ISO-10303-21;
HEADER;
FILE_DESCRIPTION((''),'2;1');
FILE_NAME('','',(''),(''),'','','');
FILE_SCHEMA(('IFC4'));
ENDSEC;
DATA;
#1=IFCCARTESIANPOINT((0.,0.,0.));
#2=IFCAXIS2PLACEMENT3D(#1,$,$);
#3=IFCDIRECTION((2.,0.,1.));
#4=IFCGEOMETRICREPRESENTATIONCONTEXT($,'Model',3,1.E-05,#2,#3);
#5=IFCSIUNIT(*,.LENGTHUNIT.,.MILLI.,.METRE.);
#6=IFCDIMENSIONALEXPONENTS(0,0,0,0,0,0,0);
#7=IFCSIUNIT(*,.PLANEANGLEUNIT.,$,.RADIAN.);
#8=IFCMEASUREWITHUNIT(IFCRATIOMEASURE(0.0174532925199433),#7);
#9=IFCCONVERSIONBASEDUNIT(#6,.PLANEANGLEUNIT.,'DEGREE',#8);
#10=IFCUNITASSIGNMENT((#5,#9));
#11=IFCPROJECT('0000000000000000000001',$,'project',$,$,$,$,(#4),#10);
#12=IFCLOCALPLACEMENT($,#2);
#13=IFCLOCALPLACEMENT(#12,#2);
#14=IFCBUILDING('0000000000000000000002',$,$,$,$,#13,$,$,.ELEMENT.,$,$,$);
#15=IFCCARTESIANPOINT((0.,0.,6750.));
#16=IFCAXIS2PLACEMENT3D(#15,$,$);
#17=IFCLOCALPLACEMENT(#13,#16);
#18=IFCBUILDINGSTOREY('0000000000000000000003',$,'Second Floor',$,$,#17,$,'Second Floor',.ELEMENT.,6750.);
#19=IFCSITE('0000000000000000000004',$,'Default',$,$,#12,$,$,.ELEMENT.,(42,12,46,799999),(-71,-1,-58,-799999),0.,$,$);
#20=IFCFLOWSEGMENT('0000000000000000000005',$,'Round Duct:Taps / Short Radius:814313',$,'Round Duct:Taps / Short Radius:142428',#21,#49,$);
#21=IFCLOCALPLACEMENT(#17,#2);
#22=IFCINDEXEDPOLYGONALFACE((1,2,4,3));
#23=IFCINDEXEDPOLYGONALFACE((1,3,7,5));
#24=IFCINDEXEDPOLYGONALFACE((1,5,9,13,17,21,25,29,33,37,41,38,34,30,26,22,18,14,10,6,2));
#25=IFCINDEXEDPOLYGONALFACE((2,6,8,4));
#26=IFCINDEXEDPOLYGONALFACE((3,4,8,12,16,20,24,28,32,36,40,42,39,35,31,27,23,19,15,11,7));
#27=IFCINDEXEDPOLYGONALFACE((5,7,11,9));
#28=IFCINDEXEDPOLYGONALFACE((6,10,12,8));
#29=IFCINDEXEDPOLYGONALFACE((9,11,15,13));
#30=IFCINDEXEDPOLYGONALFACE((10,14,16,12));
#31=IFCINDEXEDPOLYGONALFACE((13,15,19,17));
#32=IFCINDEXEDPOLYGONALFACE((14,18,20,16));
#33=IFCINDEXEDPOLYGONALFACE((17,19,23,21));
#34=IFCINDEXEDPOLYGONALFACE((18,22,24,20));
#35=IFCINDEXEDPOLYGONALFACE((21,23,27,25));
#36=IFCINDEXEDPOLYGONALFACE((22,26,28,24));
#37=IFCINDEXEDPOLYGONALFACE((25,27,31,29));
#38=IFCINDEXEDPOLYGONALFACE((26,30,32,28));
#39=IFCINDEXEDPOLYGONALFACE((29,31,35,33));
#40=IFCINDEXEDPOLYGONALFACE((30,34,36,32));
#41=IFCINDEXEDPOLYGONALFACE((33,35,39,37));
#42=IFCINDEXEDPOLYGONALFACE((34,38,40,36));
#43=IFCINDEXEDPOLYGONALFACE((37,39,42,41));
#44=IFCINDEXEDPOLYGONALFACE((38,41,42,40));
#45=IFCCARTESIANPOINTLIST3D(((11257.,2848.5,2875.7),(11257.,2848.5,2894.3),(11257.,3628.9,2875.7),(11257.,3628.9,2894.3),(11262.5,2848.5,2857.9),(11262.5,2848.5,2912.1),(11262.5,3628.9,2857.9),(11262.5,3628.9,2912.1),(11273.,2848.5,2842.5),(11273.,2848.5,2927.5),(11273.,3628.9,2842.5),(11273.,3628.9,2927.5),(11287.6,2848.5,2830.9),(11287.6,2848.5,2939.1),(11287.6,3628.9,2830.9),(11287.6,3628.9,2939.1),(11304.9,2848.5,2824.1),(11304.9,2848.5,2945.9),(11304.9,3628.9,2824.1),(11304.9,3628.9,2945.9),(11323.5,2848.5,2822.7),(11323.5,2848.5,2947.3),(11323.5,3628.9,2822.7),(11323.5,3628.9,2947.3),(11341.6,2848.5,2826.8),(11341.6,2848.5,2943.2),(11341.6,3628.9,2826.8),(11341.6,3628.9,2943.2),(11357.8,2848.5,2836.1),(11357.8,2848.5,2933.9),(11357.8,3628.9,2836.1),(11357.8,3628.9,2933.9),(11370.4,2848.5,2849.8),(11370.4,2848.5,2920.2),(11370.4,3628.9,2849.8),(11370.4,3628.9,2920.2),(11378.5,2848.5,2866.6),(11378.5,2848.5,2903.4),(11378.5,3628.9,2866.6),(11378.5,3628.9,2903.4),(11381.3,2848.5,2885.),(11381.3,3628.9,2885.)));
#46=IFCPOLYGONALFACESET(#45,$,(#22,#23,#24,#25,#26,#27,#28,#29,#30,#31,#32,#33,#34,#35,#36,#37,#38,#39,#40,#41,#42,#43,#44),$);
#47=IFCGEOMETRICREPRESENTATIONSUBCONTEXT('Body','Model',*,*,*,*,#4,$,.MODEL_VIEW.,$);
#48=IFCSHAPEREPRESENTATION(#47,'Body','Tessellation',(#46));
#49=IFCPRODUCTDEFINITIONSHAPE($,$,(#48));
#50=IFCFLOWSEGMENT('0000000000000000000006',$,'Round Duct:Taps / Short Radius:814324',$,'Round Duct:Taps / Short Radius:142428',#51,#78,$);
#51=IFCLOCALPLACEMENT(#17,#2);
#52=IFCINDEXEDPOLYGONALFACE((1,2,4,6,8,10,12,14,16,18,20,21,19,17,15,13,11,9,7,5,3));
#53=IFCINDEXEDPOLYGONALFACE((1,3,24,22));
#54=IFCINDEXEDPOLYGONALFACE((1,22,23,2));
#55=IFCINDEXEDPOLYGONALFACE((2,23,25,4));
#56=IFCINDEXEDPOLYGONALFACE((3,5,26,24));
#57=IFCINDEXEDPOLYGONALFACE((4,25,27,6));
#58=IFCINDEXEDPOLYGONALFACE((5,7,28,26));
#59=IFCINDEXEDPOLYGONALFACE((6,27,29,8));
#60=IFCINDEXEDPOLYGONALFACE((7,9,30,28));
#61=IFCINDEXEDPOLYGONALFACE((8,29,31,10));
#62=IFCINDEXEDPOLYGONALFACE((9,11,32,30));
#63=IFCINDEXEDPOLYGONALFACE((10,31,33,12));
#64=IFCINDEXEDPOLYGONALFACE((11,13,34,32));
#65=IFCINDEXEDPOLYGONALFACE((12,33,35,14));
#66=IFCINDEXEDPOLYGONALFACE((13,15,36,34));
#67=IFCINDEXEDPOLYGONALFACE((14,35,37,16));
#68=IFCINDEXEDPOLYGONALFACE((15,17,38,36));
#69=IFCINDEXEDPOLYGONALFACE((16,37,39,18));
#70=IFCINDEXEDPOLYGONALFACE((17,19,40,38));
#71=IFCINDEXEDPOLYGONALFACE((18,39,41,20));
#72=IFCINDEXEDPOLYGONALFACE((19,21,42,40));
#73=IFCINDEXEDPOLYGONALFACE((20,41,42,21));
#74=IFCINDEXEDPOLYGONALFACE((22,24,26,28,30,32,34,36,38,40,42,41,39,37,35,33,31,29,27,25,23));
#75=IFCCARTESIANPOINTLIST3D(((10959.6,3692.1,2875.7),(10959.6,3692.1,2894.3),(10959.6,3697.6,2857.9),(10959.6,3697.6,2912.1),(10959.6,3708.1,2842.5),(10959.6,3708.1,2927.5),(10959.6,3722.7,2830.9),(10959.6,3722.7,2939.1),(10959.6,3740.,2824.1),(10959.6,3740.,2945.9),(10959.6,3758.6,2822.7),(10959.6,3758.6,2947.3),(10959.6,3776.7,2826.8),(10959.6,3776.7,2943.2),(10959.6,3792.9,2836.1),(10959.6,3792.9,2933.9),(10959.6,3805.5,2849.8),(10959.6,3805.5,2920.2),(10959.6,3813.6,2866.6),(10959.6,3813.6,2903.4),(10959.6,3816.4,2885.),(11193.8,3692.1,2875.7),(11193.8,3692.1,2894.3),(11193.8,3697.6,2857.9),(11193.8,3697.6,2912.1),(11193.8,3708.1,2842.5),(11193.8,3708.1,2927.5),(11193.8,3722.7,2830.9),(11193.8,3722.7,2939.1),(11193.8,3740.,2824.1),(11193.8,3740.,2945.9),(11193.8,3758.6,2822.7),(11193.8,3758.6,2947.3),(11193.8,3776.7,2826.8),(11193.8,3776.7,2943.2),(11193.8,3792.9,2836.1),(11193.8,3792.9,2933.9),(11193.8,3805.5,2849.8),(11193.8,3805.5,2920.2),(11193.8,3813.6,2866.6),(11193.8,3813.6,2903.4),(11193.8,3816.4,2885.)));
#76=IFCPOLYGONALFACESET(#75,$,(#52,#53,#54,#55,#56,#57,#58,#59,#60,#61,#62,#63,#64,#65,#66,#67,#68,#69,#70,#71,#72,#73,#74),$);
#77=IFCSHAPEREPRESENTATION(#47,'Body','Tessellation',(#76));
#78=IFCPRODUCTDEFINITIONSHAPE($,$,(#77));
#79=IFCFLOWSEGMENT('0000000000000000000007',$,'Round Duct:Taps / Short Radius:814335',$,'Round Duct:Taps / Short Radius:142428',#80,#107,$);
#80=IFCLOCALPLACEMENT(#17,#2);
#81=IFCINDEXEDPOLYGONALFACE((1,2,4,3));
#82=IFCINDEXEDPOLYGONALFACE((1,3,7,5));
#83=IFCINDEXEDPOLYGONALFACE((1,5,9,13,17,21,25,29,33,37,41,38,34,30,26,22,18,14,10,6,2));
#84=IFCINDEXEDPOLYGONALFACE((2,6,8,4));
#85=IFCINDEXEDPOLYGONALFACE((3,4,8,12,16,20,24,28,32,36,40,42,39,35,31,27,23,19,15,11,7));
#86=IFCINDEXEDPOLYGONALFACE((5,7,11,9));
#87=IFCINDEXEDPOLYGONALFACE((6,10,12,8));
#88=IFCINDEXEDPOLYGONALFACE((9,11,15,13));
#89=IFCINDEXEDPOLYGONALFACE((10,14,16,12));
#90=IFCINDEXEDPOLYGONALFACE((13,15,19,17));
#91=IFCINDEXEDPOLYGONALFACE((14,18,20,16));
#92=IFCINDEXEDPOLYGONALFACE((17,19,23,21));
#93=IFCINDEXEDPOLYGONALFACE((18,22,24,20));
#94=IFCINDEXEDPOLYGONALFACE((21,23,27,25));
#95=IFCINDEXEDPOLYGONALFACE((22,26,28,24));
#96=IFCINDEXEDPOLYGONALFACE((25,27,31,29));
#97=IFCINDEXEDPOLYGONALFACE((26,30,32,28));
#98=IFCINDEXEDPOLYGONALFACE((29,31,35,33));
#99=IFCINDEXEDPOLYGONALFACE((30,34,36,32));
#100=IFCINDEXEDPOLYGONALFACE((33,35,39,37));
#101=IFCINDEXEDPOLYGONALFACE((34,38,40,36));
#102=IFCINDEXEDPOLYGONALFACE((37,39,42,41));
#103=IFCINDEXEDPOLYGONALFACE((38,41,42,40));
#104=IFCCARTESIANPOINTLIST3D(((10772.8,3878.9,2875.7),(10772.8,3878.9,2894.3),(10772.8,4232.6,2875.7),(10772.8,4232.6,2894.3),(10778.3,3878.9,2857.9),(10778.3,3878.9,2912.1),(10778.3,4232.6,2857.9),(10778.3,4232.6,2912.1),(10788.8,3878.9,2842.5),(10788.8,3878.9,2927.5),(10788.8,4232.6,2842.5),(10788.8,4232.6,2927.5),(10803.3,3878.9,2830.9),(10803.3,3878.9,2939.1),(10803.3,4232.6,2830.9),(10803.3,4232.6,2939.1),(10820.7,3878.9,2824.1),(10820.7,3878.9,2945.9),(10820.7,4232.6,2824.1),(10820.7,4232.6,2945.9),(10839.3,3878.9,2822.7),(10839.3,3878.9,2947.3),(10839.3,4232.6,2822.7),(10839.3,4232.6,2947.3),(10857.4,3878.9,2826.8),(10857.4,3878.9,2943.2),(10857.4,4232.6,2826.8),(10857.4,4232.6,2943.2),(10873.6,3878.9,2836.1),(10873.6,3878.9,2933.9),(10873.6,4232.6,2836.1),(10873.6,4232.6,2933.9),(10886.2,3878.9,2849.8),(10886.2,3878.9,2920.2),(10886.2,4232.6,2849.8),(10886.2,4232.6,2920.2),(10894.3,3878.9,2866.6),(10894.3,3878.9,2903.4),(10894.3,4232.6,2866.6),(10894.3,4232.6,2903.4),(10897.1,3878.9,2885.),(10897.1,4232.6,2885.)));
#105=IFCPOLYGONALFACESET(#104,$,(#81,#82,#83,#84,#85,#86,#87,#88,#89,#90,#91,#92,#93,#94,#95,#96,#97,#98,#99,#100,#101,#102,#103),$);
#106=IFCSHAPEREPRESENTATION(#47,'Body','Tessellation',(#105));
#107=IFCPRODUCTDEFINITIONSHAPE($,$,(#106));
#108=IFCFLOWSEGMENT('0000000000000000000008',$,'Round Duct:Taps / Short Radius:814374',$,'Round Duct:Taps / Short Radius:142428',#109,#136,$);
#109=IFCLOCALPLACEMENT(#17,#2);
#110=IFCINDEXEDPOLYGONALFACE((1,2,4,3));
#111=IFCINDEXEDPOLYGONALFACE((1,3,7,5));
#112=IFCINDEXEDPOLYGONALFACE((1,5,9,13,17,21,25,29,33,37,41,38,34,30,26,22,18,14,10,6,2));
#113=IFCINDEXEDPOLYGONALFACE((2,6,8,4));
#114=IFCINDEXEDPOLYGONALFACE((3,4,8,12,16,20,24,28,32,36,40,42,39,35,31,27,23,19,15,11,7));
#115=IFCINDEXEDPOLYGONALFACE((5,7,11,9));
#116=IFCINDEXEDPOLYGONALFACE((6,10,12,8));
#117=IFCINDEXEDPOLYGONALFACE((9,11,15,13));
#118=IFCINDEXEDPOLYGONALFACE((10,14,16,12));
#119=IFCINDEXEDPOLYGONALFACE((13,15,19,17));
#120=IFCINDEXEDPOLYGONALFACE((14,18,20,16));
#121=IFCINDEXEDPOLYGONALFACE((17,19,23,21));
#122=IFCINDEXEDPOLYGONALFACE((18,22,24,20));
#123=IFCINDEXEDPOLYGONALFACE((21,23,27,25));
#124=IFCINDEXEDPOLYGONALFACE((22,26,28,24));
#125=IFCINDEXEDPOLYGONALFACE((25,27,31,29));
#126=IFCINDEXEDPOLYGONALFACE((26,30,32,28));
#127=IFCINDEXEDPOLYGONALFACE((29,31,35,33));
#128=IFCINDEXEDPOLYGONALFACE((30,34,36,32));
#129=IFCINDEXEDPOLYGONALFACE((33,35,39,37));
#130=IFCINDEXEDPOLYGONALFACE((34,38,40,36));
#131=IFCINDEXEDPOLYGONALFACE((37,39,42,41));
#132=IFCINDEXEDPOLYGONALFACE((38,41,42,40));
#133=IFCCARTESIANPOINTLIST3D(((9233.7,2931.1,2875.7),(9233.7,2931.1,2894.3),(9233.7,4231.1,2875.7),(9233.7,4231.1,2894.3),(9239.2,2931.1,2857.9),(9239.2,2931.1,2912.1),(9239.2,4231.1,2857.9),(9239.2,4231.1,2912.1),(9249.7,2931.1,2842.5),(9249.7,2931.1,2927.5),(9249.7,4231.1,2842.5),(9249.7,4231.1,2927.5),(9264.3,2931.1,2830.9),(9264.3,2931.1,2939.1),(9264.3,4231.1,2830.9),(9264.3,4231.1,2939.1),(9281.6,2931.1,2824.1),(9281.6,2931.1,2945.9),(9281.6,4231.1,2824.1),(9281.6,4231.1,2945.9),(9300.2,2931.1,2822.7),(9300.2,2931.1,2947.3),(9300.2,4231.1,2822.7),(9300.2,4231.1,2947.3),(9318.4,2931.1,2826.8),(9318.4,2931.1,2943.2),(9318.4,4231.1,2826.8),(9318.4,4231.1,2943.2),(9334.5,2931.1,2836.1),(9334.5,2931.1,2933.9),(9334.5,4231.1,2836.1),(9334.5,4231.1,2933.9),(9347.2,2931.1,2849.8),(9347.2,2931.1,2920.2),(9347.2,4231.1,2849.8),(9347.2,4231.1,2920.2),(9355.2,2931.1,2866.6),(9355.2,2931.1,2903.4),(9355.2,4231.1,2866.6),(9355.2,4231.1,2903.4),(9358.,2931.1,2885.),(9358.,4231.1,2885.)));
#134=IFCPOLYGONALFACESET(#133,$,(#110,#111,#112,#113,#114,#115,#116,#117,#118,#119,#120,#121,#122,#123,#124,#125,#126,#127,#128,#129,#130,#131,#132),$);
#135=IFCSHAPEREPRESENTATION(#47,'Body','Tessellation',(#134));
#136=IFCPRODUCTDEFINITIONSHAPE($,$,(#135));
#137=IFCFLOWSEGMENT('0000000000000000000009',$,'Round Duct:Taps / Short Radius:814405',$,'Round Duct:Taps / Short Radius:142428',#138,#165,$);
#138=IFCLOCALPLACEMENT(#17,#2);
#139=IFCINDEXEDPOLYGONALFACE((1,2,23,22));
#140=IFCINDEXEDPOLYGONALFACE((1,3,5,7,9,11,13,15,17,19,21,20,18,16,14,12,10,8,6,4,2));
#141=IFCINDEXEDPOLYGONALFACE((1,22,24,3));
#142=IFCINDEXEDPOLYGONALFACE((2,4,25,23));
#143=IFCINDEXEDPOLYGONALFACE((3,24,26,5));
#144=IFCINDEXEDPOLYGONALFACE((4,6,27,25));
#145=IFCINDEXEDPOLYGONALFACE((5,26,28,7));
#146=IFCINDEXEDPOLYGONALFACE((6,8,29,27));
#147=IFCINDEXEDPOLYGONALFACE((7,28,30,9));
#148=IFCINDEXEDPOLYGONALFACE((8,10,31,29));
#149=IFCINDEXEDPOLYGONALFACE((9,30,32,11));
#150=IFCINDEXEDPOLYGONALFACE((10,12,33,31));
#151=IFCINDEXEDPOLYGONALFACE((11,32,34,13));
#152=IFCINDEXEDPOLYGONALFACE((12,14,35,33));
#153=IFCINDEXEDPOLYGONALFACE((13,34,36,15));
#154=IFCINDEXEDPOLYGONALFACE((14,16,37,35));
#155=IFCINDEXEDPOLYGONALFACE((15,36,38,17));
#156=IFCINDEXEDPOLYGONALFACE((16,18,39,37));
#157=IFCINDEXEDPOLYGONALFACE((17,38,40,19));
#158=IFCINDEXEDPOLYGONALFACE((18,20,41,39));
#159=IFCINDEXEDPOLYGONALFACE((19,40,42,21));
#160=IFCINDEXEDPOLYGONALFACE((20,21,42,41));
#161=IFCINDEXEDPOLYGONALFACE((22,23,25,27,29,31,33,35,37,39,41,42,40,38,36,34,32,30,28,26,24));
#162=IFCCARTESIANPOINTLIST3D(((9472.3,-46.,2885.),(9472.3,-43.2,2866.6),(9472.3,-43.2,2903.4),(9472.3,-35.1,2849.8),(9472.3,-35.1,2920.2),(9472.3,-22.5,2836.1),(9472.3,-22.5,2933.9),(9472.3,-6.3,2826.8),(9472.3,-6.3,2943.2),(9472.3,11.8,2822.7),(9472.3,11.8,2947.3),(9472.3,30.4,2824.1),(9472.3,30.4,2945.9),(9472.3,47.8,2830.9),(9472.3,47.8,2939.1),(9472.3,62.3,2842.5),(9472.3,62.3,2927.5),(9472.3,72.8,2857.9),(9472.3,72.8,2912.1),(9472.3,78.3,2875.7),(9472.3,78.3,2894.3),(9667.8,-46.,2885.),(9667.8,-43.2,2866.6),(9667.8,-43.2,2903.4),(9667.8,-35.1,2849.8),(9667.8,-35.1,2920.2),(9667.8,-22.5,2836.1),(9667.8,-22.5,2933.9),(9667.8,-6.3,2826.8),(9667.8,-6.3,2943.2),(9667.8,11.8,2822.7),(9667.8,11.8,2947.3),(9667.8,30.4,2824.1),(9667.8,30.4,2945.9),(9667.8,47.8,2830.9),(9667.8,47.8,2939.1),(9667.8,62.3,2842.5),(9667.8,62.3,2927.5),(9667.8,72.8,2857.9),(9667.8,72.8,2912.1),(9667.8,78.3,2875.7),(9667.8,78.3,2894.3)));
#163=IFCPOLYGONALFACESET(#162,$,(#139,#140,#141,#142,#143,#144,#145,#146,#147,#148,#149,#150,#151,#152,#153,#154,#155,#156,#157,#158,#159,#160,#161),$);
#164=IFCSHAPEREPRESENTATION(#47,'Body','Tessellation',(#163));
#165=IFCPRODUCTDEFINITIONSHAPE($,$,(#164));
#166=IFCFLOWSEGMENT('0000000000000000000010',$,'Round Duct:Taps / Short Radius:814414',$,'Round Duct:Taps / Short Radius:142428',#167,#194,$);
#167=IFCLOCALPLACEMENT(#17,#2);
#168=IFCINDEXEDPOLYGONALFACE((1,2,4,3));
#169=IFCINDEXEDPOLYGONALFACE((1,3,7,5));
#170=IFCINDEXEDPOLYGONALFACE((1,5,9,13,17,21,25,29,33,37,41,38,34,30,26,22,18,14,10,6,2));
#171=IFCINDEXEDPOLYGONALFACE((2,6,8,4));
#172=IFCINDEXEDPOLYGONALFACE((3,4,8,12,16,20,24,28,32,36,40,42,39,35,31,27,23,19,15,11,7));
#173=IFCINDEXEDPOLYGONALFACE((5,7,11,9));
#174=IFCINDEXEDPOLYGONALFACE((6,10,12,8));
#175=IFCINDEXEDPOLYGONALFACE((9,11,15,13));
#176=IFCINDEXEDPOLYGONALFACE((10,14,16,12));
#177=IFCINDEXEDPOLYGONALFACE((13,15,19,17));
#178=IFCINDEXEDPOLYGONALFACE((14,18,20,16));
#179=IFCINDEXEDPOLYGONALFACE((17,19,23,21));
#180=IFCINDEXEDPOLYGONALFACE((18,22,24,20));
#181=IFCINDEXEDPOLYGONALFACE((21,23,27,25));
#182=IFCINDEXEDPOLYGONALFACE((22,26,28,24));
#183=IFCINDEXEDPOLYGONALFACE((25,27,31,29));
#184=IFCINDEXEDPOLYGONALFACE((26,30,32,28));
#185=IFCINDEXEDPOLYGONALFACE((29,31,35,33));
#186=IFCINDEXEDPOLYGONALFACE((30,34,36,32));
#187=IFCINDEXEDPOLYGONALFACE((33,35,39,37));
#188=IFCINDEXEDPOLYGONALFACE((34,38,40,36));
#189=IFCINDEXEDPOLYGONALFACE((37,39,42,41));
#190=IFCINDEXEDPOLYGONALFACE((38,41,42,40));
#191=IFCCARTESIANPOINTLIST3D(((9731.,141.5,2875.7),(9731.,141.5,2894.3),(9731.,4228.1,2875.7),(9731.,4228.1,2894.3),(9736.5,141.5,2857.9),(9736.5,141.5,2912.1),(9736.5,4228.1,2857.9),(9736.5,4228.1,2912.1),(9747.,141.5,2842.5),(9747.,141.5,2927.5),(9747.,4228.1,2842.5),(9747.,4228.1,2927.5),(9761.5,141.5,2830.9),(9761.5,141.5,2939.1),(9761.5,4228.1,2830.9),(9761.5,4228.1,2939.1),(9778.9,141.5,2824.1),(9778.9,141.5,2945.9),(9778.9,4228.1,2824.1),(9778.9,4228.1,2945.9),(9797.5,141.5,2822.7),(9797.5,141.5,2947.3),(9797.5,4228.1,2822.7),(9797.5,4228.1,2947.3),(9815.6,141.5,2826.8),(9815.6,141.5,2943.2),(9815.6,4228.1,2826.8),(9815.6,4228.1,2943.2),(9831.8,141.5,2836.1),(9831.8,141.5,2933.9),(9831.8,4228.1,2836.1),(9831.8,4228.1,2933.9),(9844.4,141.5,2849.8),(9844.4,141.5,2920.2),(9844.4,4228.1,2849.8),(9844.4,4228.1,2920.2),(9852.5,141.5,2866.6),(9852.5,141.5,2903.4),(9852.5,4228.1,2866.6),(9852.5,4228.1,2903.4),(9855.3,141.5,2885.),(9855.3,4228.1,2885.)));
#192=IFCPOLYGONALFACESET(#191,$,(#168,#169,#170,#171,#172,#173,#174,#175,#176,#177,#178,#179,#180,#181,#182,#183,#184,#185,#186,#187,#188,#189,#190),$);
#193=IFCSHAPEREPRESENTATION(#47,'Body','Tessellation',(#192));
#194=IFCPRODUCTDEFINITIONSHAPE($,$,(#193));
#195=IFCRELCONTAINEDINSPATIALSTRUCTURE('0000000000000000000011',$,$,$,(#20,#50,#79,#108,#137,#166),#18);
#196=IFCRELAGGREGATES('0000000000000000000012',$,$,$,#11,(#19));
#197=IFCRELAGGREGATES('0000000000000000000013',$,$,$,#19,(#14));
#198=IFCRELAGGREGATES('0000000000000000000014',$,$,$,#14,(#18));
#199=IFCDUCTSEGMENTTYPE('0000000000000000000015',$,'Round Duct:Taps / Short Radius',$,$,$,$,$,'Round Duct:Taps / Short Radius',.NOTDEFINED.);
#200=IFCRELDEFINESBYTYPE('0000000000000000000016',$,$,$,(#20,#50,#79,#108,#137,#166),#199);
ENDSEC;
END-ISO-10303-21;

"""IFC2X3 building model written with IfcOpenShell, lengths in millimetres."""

from ifc_helpers import new_model, entity, si_unit, converted_unit, direction, frame, frame_2d, origin, origin_2d_with_axis, place, context, subcontext, project, spatial, circle, extrude, type_object, element, save


model = new_model("IFC2X3")

# Units and contexts
model_context = context("Model", 3, precision=1e-05, world=origin(), true_north=direction((2.0, 0.0, 1.0)))
body_context = subcontext(model_context, "Body", "Model", "MODEL_VIEW")
ifc_project = project(units=[si_unit("LENGTHUNIT", "METRE", prefix="MILLI"), converted_unit("PLANEANGLEUNIT", "DEGREE", entity("IfcRatioMeasure", 0.0174532925199433), si_unit("PLANEANGLEUNIT", "RADIAN"), dimensions=[0, 0, 0, 0, 0, 0, 0])], contexts=[model_context])

# Site, building, storey
site_placement = place(None, origin())
site = spatial("IfcSite", under=ifc_project, at=site_placement, Name="Default", CompositionType="ELEMENT", RefLatitude=(42, 12, 46, 799999), RefLongitude=(-71, -1, -58, -799999), RefElevation=0.0)
building_placement = place(site_placement, origin())
building = spatial("IfcBuilding", under=site, at=building_placement, CompositionType="ELEMENT")
storey_placement = place(building_placement, frame((0.0, 0.0, 6750.0)))
storey = spatial("IfcBuildingStorey", under=building, at=storey_placement, Name="Second Floor", LongName="Second Floor", CompositionType="ELEMENT", Elevation=6750.0)

# Flow segments
duct_segment_type = type_object("IfcDuctSegmentType", Name="Round Duct:Taps / Short Radius", ElementType="Round Duct:Taps / Short Radius", PredefinedType="NOTDEFINED")
flow_segment_1_placement = place(storey_placement, origin())
element("IfcFlowSegment", 1, at=flow_segment_1_placement, inside=storey, type_object=duct_segment_type, Name="Round Duct:Taps / Short Radius:814313", ObjectType="Round Duct:Taps / Short Radius:142428", context=body_context, shape_type="SweptSolid", body=[
    extrude(circle(Radius=62.5, at=origin_2d_with_axis()), frame((11318.8, 2848.5, 2885.0), z_axis=(0.0, 1.0, 0.0), x_axis=(1.0, 0.0, 0.0)), (0.0, 0.0, 1.0), 780.4),
])
flow_segment_2_placement = place(storey_placement, origin())
element("IfcFlowSegment", 2, at=flow_segment_2_placement, inside=storey, type_object=duct_segment_type, Name="Round Duct:Taps / Short Radius:814324", ObjectType="Round Duct:Taps / Short Radius:142428", context=body_context, shape_type="SweptSolid", body=[
    extrude(circle(Radius=62.5, at=frame_2d((0.0, 0.0), x_axis=(1.0, 0.0))), frame((10959.6, 3753.9, 2885.0), z_axis=(1.0, 0.0, 0.0), x_axis=(0.0, 1.0, 0.0)), (0.0, 0.0, 1.0), 234.2),
])
flow_segment_3_placement = place(storey_placement, origin())
element("IfcFlowSegment", 3, at=flow_segment_3_placement, inside=storey, type_object=duct_segment_type, Name="Round Duct:Taps / Short Radius:814335", ObjectType="Round Duct:Taps / Short Radius:142428", context=body_context, shape_type="SweptSolid", body=[
    extrude(circle(Radius=62.5, at=origin_2d_with_axis()), frame((10834.6, 3878.9, 2885.0), z_axis=(0.0, 1.0, 0.0), x_axis=(1.0, 0.0, 0.0)), (0.0, 0.0, 1.0), 353.7),
])
flow_segment_4_placement = place(storey_placement, origin())
element("IfcFlowSegment", 4, at=flow_segment_4_placement, inside=storey, type_object=duct_segment_type, Name="Round Duct:Taps / Short Radius:814374", ObjectType="Round Duct:Taps / Short Radius:142428", context=body_context, shape_type="SweptSolid", body=[
    extrude(circle(Radius=62.5, at=origin_2d_with_axis()), frame((9295.5, 2931.1, 2885.0), z_axis=(0.0, 1.0, 0.0), x_axis=(1.0, 0.0, 0.0)), (0.0, 0.0, 1.0), 1300.1),
])
flow_segment_5_placement = place(storey_placement, origin())
element("IfcFlowSegment", 5, at=flow_segment_5_placement, inside=storey, type_object=duct_segment_type, Name="Round Duct:Taps / Short Radius:814405", ObjectType="Round Duct:Taps / Short Radius:142428", context=body_context, shape_type="SweptSolid", body=[
    extrude(circle(Radius=62.5, at=frame_2d((0.0, 0.0), x_axis=(1.0, 0.0))), frame((9472.3, 16.5, 2885.0), z_axis=(1.0, 0.0, 0.0), x_axis=(0.0, -1.0, 0.0)), (0.0, 0.0, 1.0), 195.5),
])
flow_segment_6_placement = place(storey_placement, origin())
element("IfcFlowSegment", 6, at=flow_segment_6_placement, inside=storey, type_object=duct_segment_type, Name="Round Duct:Taps / Short Radius:814414", ObjectType="Round Duct:Taps / Short Radius:142428", context=body_context, shape_type="SweptSolid", body=[
    extrude(circle(Radius=62.5, at=origin_2d_with_axis()), frame((9792.8, 141.5, 2885.0), z_axis=(0.0, 1.0, 0.0), x_axis=(1.0, 0.0, 0.0)), (0.0, 0.0, 1.0), 4086.6),
])

save(model, "model.ifc")
